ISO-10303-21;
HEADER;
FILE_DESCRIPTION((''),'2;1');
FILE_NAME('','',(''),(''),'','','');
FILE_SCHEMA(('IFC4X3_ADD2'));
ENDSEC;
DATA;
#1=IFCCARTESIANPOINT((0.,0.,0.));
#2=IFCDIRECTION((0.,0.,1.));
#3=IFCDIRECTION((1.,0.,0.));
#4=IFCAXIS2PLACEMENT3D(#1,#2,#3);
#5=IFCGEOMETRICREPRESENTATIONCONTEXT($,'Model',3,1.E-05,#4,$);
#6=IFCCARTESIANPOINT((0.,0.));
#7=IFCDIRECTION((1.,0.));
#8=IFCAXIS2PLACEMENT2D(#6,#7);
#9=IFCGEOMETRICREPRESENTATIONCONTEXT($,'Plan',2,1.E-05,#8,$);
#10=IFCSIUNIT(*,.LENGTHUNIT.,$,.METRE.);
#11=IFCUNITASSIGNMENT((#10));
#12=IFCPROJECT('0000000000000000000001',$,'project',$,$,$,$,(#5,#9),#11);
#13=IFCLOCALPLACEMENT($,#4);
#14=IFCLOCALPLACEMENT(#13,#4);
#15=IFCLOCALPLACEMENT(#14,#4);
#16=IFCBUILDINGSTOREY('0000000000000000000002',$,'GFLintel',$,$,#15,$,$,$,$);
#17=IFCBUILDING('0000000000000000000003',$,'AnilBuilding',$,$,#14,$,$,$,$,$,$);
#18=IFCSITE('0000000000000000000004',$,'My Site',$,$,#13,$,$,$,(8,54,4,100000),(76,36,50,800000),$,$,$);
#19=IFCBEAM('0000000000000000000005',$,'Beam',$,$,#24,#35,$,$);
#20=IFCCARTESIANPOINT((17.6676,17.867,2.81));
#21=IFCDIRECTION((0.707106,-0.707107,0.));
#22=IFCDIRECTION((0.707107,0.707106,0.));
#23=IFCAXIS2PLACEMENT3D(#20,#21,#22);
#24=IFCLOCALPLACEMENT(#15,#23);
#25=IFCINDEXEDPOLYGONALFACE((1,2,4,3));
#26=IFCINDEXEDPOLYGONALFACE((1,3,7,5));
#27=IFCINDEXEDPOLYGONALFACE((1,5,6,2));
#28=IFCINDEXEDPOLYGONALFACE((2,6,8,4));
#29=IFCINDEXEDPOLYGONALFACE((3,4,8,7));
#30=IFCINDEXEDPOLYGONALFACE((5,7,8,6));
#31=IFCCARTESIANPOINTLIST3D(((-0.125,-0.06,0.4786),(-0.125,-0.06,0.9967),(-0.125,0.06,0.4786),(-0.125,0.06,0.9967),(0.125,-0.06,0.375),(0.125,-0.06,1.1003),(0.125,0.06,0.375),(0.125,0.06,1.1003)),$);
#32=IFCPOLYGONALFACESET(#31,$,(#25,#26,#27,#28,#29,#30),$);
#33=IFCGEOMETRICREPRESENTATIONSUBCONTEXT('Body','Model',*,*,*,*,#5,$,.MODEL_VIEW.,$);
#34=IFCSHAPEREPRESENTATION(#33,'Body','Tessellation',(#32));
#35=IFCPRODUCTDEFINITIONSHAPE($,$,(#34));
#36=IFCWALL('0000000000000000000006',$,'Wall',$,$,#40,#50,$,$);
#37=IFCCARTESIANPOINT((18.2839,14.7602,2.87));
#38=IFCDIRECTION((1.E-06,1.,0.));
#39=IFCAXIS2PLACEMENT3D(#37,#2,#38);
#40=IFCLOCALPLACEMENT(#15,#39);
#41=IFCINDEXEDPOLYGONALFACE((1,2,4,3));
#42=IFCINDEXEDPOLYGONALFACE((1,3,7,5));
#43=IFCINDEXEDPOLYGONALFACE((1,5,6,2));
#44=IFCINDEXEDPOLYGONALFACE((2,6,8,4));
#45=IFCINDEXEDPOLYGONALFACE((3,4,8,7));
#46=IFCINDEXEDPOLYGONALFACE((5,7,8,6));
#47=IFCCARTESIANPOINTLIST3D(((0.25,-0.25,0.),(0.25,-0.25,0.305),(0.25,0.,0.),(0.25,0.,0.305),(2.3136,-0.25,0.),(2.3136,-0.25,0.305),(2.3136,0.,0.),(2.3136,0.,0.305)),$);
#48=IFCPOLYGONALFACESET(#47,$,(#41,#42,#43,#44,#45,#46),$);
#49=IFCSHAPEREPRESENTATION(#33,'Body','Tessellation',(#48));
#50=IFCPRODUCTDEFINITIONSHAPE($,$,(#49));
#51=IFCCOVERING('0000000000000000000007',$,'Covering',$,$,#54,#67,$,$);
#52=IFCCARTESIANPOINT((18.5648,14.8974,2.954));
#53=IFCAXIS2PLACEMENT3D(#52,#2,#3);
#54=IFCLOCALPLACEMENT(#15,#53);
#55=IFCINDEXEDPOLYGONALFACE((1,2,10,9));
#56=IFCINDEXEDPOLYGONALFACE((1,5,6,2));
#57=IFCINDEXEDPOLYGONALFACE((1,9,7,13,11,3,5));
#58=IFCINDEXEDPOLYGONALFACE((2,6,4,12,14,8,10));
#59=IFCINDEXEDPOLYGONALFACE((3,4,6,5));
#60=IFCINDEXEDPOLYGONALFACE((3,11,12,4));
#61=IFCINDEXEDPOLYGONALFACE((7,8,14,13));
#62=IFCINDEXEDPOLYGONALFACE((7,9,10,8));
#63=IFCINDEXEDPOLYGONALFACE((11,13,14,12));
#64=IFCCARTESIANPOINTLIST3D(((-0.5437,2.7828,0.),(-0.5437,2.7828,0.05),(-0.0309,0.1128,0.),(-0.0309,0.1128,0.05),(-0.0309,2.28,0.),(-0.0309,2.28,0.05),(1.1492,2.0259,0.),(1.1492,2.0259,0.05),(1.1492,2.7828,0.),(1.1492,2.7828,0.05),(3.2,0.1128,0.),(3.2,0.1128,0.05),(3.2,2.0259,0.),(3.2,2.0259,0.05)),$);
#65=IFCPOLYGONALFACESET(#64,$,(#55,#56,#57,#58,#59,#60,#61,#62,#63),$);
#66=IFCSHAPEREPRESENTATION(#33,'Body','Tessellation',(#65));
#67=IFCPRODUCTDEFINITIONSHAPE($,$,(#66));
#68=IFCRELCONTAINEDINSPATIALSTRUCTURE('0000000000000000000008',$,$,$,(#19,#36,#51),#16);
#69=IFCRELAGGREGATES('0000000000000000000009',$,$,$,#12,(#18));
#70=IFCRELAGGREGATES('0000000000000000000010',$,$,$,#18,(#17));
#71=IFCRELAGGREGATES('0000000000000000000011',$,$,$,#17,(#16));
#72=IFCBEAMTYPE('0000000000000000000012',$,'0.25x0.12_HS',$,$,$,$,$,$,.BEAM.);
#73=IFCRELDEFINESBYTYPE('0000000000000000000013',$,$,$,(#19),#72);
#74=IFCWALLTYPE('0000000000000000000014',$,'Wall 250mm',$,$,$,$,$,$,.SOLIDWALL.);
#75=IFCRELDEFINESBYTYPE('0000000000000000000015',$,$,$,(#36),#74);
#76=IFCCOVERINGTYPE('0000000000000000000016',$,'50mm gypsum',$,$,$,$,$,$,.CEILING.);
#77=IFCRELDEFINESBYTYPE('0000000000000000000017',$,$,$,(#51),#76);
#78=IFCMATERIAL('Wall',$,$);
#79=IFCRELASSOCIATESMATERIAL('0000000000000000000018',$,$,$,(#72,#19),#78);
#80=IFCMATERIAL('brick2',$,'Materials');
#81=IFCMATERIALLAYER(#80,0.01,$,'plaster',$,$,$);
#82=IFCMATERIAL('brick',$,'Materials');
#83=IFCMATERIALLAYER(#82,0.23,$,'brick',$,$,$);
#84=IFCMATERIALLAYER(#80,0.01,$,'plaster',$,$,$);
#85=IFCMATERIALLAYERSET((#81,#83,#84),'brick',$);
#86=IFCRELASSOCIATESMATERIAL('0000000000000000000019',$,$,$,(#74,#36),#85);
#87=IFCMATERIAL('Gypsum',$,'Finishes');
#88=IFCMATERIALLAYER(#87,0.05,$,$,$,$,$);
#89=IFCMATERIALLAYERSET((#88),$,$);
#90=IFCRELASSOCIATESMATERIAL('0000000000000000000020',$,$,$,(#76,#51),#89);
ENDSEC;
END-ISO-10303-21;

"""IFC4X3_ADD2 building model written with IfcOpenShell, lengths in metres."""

from ifc_helpers import new_model, si_unit, frame, origin_with_axes, origin_2d_with_axis, place, context, subcontext, project, spatial, line, indexed_curve, rectangle, outline, extrude, clip, halfspace, material, layer, layer_set, layer_usage, material_profile, profile_set, profile_usage, type_object, element, save


model = new_model("IFC4X3_ADD2")

# Units and contexts
model_context = context("Model", 3, precision=1e-05, world=origin_with_axes())
plan_context = context("Plan", 2, precision=1e-05, world=origin_2d_with_axis())
body_context = subcontext(model_context, "Body", "Model", "MODEL_VIEW")
ifc_project = project(units=[si_unit("LENGTHUNIT", "METRE")], contexts=[model_context, plan_context])

# Site, building, storey
site_placement = place(None, origin_with_axes())
site = spatial("IfcSite", under=ifc_project, at=site_placement, Name="My Site", RefLatitude=(8, 54, 4, 100000), RefLongitude=(76, 36, 50, 800000))
building_placement = place(site_placement, origin_with_axes())
building = spatial("IfcBuilding", under=site, at=building_placement, Name="AnilBuilding")
storey_placement = place(building_placement, origin_with_axes())
storey = spatial("IfcBuildingStorey", under=building, at=storey_placement, Name="GFLintel")

# Beam
ifc_material_1 = material(Name="Wall")
ifc_material_profile_1 = material_profile(ifc_material_1, rectangle(XDim=0.25, YDim=0.12))
ifc_profile_set_1 = profile_set([ifc_material_profile_1], Name="concrete")
beam_type_1 = type_object("IfcBeamType", Name="0.25x0.12_HS", PredefinedType="BEAM", material=ifc_profile_set_1)
ifc_profile_usage_1 = profile_usage(ifc_profile_set_1)
beam_1_placement = place(storey_placement, frame((17.6676, 17.867, 2.81), z_axis=(0.707106, -0.707107, 0.0), x_axis=(0.707107, 0.707106, 0.0)))
element("IfcBeam", 1, at=beam_1_placement, inside=storey, type_object=beam_type_1, material=ifc_profile_usage_1, Name="Beam", context=body_context, shape_type="Clipping", body=[
    clip(clip(extrude(rectangle(XDim=0.25, YDim=0.12), origin_with_axes(), (0.0, 0.0, 1.0), 1.4753), halfspace(frame((0.125, -2.66, 0.375), z_axis=(-0.382683, 0.0, -0.92388), x_axis=(-0.000001, 1.0, 0.0)), False)), halfspace(frame((0.125, -2.66, 1.1003), z_axis=(-0.382693, 0.0, 0.923875), x_axis=(0.0, 1.0, 0.0)), False)),
])

# Wall
ifc_material_2 = material(Name="brick2", Category="Materials")
ifc_layer_1 = layer(ifc_material_2, 0.01, Name="plaster")
ifc_material_3 = material(Name="brick", Category="Materials")
ifc_layer_2 = layer(ifc_material_3, 0.23, Name="brick")
ifc_layer_3 = layer(ifc_material_2, 0.01, Name="plaster")
ifc_layer_set_1 = layer_set([ifc_layer_1, ifc_layer_2, ifc_layer_3], Name="brick")
wall_type_1 = type_object("IfcWallType", Name="Wall 250mm", PredefinedType="SOLIDWALL", material=ifc_layer_set_1)
ifc_layer_usage_1 = layer_usage(ifc_layer_set_1, "AXIS2", "NEGATIVE", 0.0)
wall_1_placement = place(storey_placement, frame((18.2839, 14.7602, 2.87), z_axis=(0.0, 0.0, 1.0), x_axis=(0.000001, 1.0, 0.0)))
element("IfcWall", 2, at=wall_1_placement, inside=storey, type_object=wall_type_1, material=ifc_layer_usage_1, Name="Wall", context=body_context, shape_type="SweptSolid", body=[
    extrude(outline(indexed_curve([(0.25, -0.25), (0.25, 0.0), (2.3136, 0.0), (2.3136, -0.25)], segments=[line(1, 2, 3, 4, 1)])), origin_with_axes(), (0.0, 0.0, 1.0), 0.305),
])

# Covering
ifc_material_4 = material(Name="Gypsum", Category="Finishes")
ifc_layer_4 = layer(ifc_material_4, 0.05)
ifc_layer_set_2 = layer_set([ifc_layer_4])
ifc_layer_usage_2 = layer_usage(ifc_layer_set_2, "AXIS3", "POSITIVE", 0.0)
covering_type_1 = type_object("IfcCoveringType", Name="50mm gypsum", PredefinedType="CEILING", material=ifc_layer_set_2)
covering_1_placement = place(storey_placement, frame((18.5648, 14.8974, 2.954), z_axis=(0.0, 0.0, 1.0), x_axis=(1.0, 0.0, 0.0)))
element("IfcCovering", 3, at=covering_1_placement, inside=storey, type_object=covering_type_1, material=ifc_layer_usage_2, Name="Covering", context=body_context, shape_type="SweptSolid", body=[
    extrude(outline(indexed_curve([(3.2, 2.0259), (1.1492, 2.0259), (1.1492, 2.7828), (-0.5437, 2.7828), (-0.0309, 2.28), (-0.0309, 0.1128), (3.2, 0.1128), (3.2, 2.0259)])), None, (0.0, 0.0, 1.0), 0.05),
])

save(model, "model.ifc")
